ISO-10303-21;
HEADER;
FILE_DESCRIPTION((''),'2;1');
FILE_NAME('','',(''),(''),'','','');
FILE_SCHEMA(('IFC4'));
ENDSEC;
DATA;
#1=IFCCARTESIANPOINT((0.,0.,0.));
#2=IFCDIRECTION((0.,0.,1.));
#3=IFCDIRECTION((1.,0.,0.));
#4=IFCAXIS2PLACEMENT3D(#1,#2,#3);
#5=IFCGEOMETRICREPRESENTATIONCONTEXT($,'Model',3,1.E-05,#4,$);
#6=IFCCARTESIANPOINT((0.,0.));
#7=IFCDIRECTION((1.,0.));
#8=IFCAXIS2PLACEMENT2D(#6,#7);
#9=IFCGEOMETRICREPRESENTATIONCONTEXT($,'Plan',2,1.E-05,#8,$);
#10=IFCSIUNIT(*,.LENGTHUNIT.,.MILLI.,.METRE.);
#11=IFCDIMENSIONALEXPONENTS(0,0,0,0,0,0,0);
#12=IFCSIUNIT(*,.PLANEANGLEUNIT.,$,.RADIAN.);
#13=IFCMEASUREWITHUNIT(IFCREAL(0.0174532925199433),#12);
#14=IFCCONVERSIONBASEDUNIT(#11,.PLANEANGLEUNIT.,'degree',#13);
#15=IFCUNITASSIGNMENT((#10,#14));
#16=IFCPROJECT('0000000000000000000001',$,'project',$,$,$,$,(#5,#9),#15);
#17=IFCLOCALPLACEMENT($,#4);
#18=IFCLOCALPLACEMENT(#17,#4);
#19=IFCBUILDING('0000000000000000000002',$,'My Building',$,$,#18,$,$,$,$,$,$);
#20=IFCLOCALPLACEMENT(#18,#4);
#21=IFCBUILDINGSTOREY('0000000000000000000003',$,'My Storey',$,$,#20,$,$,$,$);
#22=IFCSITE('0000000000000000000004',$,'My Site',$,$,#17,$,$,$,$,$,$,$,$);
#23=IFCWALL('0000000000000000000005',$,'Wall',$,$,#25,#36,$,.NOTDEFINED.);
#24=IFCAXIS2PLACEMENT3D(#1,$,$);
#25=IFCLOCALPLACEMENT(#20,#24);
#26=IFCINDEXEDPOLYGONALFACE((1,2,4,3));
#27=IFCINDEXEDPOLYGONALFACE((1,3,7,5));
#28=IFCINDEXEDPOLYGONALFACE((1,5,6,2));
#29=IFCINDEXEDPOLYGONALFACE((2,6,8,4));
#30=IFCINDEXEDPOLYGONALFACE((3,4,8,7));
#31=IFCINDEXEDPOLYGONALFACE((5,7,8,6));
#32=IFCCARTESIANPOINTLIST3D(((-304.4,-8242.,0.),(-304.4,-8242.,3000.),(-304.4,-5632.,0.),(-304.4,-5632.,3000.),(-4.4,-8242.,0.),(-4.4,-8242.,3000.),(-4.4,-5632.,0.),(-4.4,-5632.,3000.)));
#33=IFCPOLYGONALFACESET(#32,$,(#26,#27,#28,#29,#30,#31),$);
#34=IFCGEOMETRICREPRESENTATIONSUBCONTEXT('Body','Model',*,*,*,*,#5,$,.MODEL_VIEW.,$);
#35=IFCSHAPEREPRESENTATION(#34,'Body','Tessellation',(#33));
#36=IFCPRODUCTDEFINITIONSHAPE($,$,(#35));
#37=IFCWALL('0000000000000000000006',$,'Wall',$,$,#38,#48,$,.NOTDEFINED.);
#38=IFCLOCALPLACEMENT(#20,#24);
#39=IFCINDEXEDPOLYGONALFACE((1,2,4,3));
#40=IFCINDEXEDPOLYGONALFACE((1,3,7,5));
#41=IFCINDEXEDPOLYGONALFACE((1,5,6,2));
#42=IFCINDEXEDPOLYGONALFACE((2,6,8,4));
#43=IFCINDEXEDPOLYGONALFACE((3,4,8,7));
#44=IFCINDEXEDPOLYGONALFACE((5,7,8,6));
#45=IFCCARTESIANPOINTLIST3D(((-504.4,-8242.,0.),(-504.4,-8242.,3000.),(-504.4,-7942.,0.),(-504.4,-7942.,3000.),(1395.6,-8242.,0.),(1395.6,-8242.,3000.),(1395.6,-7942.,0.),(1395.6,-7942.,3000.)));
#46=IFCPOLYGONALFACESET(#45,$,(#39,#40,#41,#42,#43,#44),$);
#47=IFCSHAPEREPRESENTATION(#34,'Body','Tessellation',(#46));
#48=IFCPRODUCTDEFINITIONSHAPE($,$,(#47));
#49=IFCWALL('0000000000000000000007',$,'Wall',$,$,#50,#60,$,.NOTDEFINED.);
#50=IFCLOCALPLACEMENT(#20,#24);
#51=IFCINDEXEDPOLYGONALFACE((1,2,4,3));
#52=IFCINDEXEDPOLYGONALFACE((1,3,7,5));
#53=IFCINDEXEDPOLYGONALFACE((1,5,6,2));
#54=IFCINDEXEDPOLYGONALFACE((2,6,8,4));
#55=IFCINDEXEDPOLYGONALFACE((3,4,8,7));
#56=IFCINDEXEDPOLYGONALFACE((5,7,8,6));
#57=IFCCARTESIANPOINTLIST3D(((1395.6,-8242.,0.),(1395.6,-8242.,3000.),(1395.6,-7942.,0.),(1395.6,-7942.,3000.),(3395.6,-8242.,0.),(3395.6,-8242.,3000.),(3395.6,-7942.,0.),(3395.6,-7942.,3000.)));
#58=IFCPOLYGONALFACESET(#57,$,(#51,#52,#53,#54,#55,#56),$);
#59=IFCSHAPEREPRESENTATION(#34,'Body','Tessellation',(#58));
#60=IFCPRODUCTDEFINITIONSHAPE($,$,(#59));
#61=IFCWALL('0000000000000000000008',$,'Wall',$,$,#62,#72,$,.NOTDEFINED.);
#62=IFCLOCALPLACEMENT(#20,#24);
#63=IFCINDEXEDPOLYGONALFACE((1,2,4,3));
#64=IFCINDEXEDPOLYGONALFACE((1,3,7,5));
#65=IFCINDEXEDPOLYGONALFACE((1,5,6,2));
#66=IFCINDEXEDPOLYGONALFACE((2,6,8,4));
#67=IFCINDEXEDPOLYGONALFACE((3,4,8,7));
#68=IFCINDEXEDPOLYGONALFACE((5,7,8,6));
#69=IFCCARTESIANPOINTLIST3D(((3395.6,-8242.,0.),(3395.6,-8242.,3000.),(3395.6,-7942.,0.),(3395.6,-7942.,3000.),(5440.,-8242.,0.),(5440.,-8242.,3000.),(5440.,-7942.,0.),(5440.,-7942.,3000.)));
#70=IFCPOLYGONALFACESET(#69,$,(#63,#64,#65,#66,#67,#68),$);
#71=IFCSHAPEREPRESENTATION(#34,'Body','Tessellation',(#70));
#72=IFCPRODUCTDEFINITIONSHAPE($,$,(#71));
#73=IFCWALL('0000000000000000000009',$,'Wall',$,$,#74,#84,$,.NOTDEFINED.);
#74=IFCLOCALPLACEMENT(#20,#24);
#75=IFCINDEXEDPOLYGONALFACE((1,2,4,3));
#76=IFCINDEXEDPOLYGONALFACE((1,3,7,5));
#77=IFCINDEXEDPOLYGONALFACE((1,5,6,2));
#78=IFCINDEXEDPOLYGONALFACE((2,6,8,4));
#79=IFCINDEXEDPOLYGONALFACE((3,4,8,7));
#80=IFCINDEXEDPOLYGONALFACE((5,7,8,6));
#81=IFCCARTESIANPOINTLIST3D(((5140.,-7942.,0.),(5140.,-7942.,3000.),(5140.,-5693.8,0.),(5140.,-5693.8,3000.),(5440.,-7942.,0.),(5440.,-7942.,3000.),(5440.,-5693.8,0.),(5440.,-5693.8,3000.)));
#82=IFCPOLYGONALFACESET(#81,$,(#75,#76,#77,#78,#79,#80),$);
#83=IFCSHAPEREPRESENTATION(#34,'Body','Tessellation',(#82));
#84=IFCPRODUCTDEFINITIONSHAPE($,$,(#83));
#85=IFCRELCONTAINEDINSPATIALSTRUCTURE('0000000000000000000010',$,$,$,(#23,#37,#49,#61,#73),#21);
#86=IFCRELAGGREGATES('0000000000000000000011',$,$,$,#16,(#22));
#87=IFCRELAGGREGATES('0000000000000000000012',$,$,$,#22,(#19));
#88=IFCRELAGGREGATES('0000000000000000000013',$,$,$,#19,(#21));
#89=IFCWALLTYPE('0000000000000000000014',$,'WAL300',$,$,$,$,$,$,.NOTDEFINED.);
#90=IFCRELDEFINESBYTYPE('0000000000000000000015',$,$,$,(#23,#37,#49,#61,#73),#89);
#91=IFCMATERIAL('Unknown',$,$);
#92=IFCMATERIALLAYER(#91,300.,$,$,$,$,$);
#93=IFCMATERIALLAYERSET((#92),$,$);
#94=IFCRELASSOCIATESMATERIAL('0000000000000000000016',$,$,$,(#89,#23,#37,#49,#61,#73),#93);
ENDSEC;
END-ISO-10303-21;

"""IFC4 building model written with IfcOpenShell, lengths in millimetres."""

from ifc_helpers import new_model, entity, si_unit, converted_unit, frame, origin_with_axes, origin_2d_with_axis, place, context, subcontext, project, spatial, indexed_curve, outline, extrude, material, layer, layer_set, layer_usage, type_object, element, save


model = new_model("IFC4")

# Units and contexts
model_context = context("Model", 3, precision=1e-05, world=origin_with_axes())
plan_context = context("Plan", 2, precision=1e-05, world=origin_2d_with_axis())
body_context = subcontext(model_context, "Body", "Model", "MODEL_VIEW")
ifc_project = project(units=[si_unit("LENGTHUNIT", "METRE", prefix="MILLI"), converted_unit("PLANEANGLEUNIT", "degree", entity("IfcReal", 0.0174532925199433), si_unit("PLANEANGLEUNIT", "RADIAN"), dimensions=[0, 0, 0, 0, 0, 0, 0])], contexts=[model_context, plan_context])

# Site, building, storey
site_placement = place(None, origin_with_axes())
site = spatial("IfcSite", under=ifc_project, at=site_placement, Name="My Site")
building_placement = place(site_placement, origin_with_axes())
building = spatial("IfcBuilding", under=site, at=building_placement, Name="My Building")
storey_placement = place(building_placement, origin_with_axes())
storey = spatial("IfcBuildingStorey", under=building, at=storey_placement, Name="My Storey")

# Shared definitions
ifc_material = material(Name="Unknown")

# Shared definitions
ifc_layer_1 = layer(ifc_material, 300.0)
ifc_layer_set_1 = layer_set([ifc_layer_1])
wall_type_1 = type_object("IfcWallType", Name="WAL300", PredefinedType="NOTDEFINED", material=ifc_layer_set_1)

# Walls
ifc_layer_usage_1 = layer_usage(ifc_layer_set_1, "AXIS2", "POSITIVE", 0.0)
wall_1_placement = place(storey_placement, frame((-4.4, -8242.0, 0.0), z_axis=(0.0, 0.0, 1.0), x_axis=(0.000001, 1.0, 0.0)))
element("IfcWall", 1, at=wall_1_placement, inside=storey, type_object=wall_type_1, material=ifc_layer_usage_1, Name="Wall", PredefinedType="NOTDEFINED", context=body_context, shape_type="SweptSolid", body=[
    extrude(outline(indexed_curve([(0.0, 0.0), (0.0, 300.0), (2610.0, 300.0), (2610.0, 0.0), (0.0, 0.0)], self_intersect=False)), origin_with_axes(), (0.0, 0.0, 1.0), 3000.0),
])
ifc_layer_usage_2 = layer_usage(ifc_layer_set_1, "AXIS2", "POSITIVE", 0.0)
wall_2_placement = place(storey_placement, frame((1395.6, -7942.0, 0.0), z_axis=(0.0, 0.0, 1.0), x_axis=(-1.0, 0.000001, 0.0)))
element("IfcWall", 2, at=wall_2_placement, inside=storey, type_object=wall_type_1, material=ifc_layer_usage_2, Name="Wall", PredefinedType="NOTDEFINED", context=body_context, shape_type="SweptSolid", body=[
    extrude(outline(indexed_curve([(0.0, 0.0), (0.0, 300.0), (1900.0, 300.0), (1900.0, 0.0), (0.0, 0.0)], self_intersect=False)), origin_with_axes(), (0.0, 0.0, 1.0), 3000.0),
])
ifc_layer_usage_3 = layer_usage(ifc_layer_set_1, "AXIS2", "POSITIVE", 0.0)
wall_3_placement = place(storey_placement, frame((1395.6, -8242.0, 0.0), z_axis=(0.0, 0.0, 1.0), x_axis=(1.0, -0.000001, 0.0)))
element("IfcWall", 3, at=wall_3_placement, inside=storey, type_object=wall_type_1, material=ifc_layer_usage_3, Name="Wall", PredefinedType="NOTDEFINED", context=body_context, shape_type="SweptSolid", body=[
    extrude(outline(indexed_curve([(0.0, 0.0), (0.0, 300.0), (2000.0, 300.0), (2000.0, 0.0), (0.0, 0.0)], self_intersect=False)), origin_with_axes(), (0.0, 0.0, 1.0), 3000.0),
])
ifc_layer_usage_4 = layer_usage(ifc_layer_set_1, "AXIS2", "POSITIVE", 0.0)
wall_4_placement = place(storey_placement, frame((5440.0, -7942.0, 0.0), z_axis=(0.0, 0.0, 1.0), x_axis=(-1.0, 0.000002, 0.0)))
element("IfcWall", 4, at=wall_4_placement, inside=storey, type_object=wall_type_1, material=ifc_layer_usage_4, Name="Wall", PredefinedType="NOTDEFINED", context=body_context, shape_type="SweptSolid", body=[
    extrude(outline(indexed_curve([(0.0, 0.0), (0.0, 300.0), (2044.4, 300.0), (2044.4, 0.0), (0.0, 0.0)], self_intersect=False)), origin_with_axes(), (0.0, 0.0, 1.0), 3000.0),
])
ifc_layer_usage_5 = layer_usage(ifc_layer_set_1, "AXIS2", "POSITIVE", 0.0)
wall_5_placement = place(storey_placement, frame((5140.0, -5693.8, 0.0), z_axis=(0.0, 0.0, 1.0), x_axis=(-0.000001, -1.0, 0.0)))
element("IfcWall", 5, at=wall_5_placement, inside=storey, type_object=wall_type_1, material=ifc_layer_usage_5, Name="Wall", PredefinedType="NOTDEFINED", context=body_context, shape_type="SweptSolid", body=[
    extrude(outline(indexed_curve([(0.0, 0.0), (0.0, 300.0), (2248.1, 300.0), (2248.1, 0.0), (0.0, 0.0)], self_intersect=False)), origin_with_axes(), (0.0, 0.0, 1.0), 3000.0),
])

save(model, "model.ifc")
